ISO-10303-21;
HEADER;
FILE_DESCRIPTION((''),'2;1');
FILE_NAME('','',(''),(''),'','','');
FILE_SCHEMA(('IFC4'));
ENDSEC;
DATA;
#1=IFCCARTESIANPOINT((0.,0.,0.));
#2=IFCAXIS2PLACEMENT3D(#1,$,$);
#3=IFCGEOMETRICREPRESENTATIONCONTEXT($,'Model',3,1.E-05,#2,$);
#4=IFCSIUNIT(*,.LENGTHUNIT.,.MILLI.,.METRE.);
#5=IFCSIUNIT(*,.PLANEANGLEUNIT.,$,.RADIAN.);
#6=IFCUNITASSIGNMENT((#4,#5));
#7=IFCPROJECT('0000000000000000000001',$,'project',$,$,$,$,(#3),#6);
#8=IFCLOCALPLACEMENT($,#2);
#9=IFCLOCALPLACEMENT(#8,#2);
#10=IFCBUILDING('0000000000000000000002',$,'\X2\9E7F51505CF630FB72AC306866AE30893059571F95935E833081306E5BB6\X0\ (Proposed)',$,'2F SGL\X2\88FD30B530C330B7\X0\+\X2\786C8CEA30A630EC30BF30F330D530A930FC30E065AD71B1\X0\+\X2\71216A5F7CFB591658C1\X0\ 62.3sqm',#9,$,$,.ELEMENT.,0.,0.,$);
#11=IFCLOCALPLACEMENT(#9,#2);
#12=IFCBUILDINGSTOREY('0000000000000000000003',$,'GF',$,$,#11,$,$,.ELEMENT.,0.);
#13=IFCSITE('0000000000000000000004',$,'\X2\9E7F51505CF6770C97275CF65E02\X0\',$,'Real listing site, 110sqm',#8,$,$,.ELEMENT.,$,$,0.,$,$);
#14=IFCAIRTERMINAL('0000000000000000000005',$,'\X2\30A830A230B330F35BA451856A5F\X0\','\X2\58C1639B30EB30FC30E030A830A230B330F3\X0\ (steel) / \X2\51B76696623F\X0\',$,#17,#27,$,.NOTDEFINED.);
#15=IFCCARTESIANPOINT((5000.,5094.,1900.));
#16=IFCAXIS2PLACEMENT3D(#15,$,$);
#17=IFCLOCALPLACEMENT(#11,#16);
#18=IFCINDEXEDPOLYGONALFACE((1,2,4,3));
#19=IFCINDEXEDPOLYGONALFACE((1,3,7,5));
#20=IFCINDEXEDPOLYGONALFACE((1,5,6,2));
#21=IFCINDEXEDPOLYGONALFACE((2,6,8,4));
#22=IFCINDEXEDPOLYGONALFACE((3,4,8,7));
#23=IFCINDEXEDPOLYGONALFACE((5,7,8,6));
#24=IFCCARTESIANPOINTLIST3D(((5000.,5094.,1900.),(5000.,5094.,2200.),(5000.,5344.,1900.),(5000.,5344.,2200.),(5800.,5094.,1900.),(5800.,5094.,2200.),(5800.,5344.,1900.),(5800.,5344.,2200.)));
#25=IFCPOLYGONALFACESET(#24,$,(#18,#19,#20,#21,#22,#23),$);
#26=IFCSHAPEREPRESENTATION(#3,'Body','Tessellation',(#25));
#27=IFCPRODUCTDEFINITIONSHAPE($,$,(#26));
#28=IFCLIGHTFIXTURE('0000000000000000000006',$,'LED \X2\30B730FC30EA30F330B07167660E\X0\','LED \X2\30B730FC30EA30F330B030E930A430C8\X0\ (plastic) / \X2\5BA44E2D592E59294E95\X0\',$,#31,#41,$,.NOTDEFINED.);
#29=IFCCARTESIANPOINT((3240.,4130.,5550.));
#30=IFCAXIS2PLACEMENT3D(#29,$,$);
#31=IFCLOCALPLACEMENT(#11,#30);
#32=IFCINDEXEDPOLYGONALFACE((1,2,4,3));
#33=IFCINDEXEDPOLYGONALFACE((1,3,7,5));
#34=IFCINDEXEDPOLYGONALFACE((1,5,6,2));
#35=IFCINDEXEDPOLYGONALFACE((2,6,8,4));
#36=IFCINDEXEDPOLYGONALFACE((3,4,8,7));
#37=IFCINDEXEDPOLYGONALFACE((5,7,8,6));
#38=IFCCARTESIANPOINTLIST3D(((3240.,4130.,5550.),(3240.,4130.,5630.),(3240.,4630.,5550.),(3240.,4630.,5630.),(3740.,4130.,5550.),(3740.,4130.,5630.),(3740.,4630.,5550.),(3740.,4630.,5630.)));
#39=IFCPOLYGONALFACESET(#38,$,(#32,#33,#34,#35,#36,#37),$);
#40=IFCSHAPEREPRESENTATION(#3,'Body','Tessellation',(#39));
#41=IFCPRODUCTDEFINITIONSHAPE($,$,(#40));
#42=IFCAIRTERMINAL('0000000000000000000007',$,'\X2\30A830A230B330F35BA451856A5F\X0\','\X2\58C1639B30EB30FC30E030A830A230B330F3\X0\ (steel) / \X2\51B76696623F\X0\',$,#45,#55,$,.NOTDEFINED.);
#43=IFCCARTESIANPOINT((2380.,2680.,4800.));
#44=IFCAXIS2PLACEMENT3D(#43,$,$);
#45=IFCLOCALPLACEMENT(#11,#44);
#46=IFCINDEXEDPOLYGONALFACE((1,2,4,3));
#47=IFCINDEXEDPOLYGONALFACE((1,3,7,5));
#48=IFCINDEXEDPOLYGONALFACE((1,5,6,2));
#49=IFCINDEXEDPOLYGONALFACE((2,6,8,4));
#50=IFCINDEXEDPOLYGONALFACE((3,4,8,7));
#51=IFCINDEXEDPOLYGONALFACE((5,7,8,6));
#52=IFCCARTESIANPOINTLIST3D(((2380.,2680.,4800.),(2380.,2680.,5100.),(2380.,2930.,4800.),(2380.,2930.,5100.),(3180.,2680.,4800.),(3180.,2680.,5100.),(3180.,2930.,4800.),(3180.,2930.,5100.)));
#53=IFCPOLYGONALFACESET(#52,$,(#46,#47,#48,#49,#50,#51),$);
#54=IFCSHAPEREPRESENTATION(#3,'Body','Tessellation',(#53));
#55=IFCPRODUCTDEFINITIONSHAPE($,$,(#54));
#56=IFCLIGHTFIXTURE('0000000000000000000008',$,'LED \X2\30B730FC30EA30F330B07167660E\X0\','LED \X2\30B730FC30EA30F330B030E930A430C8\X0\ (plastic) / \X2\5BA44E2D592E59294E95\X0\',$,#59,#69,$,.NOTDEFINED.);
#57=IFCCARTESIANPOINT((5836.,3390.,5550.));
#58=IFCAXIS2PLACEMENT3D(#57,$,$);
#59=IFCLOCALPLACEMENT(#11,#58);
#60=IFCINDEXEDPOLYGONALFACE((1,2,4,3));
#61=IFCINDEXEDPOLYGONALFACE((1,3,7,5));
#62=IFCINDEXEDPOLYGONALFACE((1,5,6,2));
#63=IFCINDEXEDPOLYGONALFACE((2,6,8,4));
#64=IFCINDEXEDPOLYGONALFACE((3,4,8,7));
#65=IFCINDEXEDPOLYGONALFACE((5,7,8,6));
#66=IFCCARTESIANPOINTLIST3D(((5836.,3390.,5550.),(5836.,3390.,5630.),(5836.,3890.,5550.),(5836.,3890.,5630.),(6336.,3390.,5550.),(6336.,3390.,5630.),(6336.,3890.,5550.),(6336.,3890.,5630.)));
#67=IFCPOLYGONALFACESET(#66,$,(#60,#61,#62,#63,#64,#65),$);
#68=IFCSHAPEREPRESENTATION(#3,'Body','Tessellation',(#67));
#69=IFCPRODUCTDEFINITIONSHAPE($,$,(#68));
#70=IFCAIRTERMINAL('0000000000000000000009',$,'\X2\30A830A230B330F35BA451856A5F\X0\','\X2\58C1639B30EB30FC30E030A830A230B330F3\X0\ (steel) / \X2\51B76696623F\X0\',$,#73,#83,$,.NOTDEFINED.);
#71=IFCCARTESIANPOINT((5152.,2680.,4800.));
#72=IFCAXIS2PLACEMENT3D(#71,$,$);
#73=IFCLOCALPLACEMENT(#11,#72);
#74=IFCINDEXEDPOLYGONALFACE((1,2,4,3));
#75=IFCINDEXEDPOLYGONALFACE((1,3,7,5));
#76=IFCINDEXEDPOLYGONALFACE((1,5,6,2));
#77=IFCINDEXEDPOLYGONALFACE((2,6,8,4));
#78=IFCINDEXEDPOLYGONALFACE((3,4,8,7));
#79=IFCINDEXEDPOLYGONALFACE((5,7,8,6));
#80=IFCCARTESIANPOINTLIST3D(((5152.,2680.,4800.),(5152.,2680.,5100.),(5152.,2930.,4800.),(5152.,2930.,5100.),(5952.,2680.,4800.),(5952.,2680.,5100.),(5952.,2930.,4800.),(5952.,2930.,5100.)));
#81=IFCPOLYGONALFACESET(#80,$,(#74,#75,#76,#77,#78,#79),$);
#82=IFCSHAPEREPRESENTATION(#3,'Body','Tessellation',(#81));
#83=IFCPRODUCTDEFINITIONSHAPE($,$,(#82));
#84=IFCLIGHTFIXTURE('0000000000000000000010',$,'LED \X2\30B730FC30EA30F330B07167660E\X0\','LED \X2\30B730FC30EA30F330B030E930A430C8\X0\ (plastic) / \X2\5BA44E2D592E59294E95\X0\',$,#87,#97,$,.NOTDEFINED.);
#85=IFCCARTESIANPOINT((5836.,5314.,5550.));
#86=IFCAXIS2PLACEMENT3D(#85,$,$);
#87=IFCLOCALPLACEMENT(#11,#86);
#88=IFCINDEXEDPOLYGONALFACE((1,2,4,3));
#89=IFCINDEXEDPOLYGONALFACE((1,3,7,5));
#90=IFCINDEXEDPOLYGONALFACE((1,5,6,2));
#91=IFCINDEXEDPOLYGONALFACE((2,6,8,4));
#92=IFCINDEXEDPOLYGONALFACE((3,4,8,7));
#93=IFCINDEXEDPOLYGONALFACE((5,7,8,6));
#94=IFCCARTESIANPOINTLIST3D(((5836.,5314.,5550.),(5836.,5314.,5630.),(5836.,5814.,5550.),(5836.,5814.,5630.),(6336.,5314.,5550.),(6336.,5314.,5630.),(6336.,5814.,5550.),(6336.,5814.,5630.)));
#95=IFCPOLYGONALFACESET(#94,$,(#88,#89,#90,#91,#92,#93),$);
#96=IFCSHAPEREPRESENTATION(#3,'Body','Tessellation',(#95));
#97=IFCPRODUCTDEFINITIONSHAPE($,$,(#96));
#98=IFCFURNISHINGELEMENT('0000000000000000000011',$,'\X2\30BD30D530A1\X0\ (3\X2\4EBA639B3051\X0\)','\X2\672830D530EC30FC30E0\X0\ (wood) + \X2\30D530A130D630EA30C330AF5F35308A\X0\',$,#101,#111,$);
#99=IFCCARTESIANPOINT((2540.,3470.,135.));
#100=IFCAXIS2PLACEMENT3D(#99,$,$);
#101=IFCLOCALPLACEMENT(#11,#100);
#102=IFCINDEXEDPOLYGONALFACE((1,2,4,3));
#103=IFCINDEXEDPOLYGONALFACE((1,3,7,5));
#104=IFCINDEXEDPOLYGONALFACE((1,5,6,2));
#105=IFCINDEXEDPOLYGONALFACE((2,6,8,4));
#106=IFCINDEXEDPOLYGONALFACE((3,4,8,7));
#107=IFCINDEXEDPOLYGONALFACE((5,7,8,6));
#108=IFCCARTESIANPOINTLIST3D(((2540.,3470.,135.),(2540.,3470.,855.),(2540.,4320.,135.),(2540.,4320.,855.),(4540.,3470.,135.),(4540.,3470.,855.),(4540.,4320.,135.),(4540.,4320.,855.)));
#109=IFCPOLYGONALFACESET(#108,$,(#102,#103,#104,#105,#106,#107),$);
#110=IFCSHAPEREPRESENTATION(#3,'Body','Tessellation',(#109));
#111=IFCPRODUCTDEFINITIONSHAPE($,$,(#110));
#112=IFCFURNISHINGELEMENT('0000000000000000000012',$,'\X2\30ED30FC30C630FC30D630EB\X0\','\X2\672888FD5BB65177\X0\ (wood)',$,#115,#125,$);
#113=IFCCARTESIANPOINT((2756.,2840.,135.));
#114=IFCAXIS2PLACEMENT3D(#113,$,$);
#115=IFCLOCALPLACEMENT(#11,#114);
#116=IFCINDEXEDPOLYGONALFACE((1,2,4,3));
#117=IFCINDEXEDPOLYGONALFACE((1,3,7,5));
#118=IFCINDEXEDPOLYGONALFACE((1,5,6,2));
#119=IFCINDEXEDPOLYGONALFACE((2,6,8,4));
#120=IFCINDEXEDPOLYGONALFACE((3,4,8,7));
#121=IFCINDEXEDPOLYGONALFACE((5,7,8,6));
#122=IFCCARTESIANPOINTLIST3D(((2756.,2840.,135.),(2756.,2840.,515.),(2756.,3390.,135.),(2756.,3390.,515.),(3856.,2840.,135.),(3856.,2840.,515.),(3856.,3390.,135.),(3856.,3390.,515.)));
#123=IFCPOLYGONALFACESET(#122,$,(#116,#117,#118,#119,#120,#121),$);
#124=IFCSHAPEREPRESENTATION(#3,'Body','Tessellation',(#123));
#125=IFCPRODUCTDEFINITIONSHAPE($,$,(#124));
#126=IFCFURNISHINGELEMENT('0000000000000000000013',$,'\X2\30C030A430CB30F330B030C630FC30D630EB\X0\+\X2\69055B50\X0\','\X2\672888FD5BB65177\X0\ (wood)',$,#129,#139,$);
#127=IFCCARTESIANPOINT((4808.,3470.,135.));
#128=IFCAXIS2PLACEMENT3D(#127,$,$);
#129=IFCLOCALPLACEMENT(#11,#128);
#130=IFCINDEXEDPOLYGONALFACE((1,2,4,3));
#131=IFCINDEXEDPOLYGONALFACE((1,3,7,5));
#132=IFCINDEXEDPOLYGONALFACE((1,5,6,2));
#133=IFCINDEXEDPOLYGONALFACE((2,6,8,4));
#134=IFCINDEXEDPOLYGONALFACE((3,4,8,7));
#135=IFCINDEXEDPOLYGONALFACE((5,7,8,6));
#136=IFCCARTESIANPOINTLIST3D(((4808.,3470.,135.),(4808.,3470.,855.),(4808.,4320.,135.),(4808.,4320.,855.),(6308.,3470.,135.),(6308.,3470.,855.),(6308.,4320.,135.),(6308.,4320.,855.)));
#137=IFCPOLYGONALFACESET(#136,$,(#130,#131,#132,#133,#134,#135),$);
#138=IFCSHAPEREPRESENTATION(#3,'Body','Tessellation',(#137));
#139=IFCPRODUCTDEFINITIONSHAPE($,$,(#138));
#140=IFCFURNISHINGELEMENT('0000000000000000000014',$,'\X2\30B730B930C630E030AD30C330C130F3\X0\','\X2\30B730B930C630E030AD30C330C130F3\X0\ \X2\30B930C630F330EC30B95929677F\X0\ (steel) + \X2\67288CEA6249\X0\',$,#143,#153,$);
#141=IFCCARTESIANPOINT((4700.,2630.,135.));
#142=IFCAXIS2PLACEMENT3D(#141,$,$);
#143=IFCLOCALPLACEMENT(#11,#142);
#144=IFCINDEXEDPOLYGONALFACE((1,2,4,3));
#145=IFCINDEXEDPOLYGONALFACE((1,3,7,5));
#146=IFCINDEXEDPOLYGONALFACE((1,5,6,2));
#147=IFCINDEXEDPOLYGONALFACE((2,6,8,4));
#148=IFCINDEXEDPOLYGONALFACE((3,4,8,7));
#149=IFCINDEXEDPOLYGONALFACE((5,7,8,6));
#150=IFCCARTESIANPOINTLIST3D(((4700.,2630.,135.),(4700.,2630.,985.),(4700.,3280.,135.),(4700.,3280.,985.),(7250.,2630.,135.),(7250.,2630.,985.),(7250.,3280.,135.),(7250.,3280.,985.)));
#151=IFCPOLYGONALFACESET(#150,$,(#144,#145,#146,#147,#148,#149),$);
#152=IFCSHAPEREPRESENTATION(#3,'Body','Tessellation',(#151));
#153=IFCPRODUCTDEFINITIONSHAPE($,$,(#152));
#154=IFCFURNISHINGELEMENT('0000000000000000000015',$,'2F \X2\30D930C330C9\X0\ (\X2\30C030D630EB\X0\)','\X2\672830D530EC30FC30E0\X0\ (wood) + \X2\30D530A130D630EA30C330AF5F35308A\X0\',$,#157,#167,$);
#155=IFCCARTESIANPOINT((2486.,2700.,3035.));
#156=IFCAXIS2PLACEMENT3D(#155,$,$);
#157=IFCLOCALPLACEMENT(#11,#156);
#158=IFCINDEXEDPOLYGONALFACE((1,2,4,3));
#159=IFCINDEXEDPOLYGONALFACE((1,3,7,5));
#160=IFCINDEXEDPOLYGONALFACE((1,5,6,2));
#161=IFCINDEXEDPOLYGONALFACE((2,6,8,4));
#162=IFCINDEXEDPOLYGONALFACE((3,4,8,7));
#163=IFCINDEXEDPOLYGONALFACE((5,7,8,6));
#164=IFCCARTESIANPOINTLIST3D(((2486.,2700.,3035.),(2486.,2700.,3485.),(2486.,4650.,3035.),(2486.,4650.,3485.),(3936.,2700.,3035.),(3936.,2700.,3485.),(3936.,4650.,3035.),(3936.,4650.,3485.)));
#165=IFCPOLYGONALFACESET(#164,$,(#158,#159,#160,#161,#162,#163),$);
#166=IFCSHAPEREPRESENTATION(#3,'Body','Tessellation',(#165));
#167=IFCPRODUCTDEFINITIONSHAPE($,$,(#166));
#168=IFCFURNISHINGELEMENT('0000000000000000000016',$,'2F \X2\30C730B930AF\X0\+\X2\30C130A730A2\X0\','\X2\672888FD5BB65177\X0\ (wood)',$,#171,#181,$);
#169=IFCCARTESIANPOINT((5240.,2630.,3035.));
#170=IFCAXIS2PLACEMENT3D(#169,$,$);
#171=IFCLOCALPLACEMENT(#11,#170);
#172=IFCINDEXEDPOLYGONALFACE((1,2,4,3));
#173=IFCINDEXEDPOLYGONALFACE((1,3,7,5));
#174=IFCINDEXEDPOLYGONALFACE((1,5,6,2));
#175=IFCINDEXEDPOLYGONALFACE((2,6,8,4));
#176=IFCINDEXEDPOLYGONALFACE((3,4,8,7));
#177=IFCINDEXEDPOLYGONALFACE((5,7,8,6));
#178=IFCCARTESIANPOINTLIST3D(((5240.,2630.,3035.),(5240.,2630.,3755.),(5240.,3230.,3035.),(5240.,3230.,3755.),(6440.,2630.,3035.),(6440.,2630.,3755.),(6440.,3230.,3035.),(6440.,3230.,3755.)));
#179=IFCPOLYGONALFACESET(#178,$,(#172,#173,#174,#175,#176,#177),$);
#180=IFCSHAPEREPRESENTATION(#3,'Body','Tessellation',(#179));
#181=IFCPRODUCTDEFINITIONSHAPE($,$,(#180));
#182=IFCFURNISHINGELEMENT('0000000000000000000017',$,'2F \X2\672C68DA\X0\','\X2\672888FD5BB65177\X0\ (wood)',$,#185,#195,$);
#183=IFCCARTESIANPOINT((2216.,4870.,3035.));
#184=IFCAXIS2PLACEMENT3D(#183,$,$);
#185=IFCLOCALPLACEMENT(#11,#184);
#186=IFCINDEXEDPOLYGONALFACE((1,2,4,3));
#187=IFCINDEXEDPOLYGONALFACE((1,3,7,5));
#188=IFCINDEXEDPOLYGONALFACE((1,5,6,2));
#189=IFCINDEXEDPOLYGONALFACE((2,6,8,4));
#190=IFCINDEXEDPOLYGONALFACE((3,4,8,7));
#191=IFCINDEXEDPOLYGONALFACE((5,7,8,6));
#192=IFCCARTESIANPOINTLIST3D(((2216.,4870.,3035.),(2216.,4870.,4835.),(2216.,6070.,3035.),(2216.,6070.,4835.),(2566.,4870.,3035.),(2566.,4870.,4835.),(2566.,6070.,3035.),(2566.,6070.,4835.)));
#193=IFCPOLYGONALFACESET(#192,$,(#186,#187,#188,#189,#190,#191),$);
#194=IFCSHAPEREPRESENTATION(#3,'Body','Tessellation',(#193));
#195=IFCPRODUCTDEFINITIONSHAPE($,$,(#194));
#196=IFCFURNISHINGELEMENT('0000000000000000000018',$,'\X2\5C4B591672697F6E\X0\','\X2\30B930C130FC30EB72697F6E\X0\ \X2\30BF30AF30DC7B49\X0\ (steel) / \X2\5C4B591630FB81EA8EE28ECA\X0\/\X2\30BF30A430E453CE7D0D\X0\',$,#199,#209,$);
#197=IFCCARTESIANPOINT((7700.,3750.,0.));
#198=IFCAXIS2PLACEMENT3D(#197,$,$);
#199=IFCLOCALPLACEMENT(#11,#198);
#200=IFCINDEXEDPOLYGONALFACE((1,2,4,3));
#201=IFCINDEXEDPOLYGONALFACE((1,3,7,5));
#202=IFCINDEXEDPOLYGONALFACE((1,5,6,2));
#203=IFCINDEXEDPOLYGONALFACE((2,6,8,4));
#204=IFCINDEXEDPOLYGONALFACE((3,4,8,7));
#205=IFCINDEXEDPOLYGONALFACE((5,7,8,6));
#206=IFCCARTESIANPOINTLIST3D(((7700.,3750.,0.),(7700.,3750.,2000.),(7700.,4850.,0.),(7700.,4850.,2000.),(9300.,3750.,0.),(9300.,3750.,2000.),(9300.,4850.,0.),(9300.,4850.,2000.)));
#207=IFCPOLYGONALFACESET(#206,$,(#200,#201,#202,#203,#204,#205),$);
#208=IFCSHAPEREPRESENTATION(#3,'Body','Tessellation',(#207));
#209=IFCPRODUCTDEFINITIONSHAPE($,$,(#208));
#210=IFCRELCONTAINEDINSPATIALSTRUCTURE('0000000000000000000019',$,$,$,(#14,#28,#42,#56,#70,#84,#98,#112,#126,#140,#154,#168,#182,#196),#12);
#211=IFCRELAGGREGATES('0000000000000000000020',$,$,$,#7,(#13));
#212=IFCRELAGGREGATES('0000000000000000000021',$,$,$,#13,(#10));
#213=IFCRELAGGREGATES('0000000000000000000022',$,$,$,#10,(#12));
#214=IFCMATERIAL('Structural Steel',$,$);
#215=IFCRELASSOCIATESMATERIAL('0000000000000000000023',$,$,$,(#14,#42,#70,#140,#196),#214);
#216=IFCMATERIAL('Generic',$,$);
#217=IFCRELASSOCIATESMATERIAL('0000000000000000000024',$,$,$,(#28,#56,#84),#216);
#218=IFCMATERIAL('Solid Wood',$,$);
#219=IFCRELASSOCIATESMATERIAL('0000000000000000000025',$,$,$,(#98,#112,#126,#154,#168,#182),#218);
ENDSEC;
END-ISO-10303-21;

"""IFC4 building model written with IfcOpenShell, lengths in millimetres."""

from ifc_helpers import new_model, si_unit, frame, frame_2d, origin, place, context, project, spatial, rectangle, extrude, material, element, save


model = new_model("IFC4")

# Units and contexts
model_context = context("Model", 3, precision=1e-05, world=origin())
ifc_project = project(units=[si_unit("LENGTHUNIT", "METRE", prefix="MILLI"), si_unit("PLANEANGLEUNIT", "RADIAN")], contexts=[model_context])

# Site, building, storey
site_placement = place(None, origin())
site = spatial("IfcSite", under=ifc_project, at=site_placement, Name="鹿児島県霧島市", ObjectType="Real listing site, 110sqm", CompositionType="ELEMENT", RefElevation=0.0)
building_placement = place(site_placement, origin())
building = spatial("IfcBuilding", under=site, at=building_placement, Name="鹿児島・犬と暮らす土間広めの家 (Proposed)", ObjectType="2F SGL製サッシ+硬質ウレタンフォーム断熱+無機系外壁 62.3sqm", CompositionType="ELEMENT", ElevationOfRefHeight=0.0, ElevationOfTerrain=0.0)
storey_placement = place(building_placement, origin())
storey = spatial("IfcBuildingStorey", under=building, at=storey_placement, Name="GF", CompositionType="ELEMENT", Elevation=0.0)

# Shared definitions
ifc_material_1 = material(Name="Solid Wood")

# Shared definitions
ifc_material_2 = material(Name="Structural Steel")

# Shared definitions
ifc_material_3 = material(Name="Generic")

# Air terminal
air_terminal_1_placement = place(storey_placement, frame((5000.0, 5094.0, 1900.0)))
element("IfcAirTerminal", 1, at=air_terminal_1_placement, inside=storey, material=ifc_material_2, Name="エアコン室内機", Description="壁掛ルームエアコン (steel) / 冷暖房", PredefinedType="NOTDEFINED", context=model_context, shape_type="SweptSolid", body=[
    extrude(rectangle(XDim=800.0, YDim=250.0, at=frame_2d((400.0, 125.0))), frame((5000.0, 5094.0, 1900.0)), (0.0, 0.0, 1.0), 300.0),
])

# Light fixture
light_fixture_1_placement = place(storey_placement, frame((3240.0, 4130.0, 5550.0)))
element("IfcLightFixture", 2, at=light_fixture_1_placement, inside=storey, material=ifc_material_3, Name="LED シーリング照明", Description="LED シーリングライト (plastic) / 室中央天井", PredefinedType="NOTDEFINED", context=model_context, shape_type="SweptSolid", body=[
    extrude(rectangle(XDim=500.0, YDim=500.0, at=frame_2d((250.0, 250.0))), frame((3240.0, 4130.0, 5550.0)), (0.0, 0.0, 1.0), 80.0),
])

# Air terminal
air_terminal_2_placement = place(storey_placement, frame((2380.0, 2680.0, 4800.0)))
element("IfcAirTerminal", 3, at=air_terminal_2_placement, inside=storey, material=ifc_material_2, Name="エアコン室内機", Description="壁掛ルームエアコン (steel) / 冷暖房", PredefinedType="NOTDEFINED", context=model_context, shape_type="SweptSolid", body=[
    extrude(rectangle(XDim=800.0, YDim=250.0, at=frame_2d((400.0, 125.0))), frame((2380.0, 2680.0, 4800.0)), (0.0, 0.0, 1.0), 300.0),
])

# Light fixture
light_fixture_2_placement = place(storey_placement, frame((5836.0, 3390.0, 5550.0)))
element("IfcLightFixture", 4, at=light_fixture_2_placement, inside=storey, material=ifc_material_3, Name="LED シーリング照明", Description="LED シーリングライト (plastic) / 室中央天井", PredefinedType="NOTDEFINED", context=model_context, shape_type="SweptSolid", body=[
    extrude(rectangle(XDim=500.0, YDim=500.0, at=frame_2d((250.0, 250.0))), frame((5836.0, 3390.0, 5550.0)), (0.0, 0.0, 1.0), 80.0),
])

# Air terminal
air_terminal_3_placement = place(storey_placement, frame((5152.0, 2680.0, 4800.0)))
element("IfcAirTerminal", 5, at=air_terminal_3_placement, inside=storey, material=ifc_material_2, Name="エアコン室内機", Description="壁掛ルームエアコン (steel) / 冷暖房", PredefinedType="NOTDEFINED", context=model_context, shape_type="SweptSolid", body=[
    extrude(rectangle(XDim=800.0, YDim=250.0, at=frame_2d((400.0, 125.0))), frame((5152.0, 2680.0, 4800.0)), (0.0, 0.0, 1.0), 300.0),
])

# Light fixture
light_fixture_3_placement = place(storey_placement, frame((5836.0, 5314.0, 5550.0)))
element("IfcLightFixture", 6, at=light_fixture_3_placement, inside=storey, material=ifc_material_3, Name="LED シーリング照明", Description="LED シーリングライト (plastic) / 室中央天井", PredefinedType="NOTDEFINED", context=model_context, shape_type="SweptSolid", body=[
    extrude(rectangle(XDim=500.0, YDim=500.0, at=frame_2d((250.0, 250.0))), frame((5836.0, 5314.0, 5550.0)), (0.0, 0.0, 1.0), 80.0),
])

# Furnishing elements
furnishing_1_placement = place(storey_placement, frame((2540.0, 3470.0, 135.0)))
element("IfcFurnishingElement", 7, at=furnishing_1_placement, inside=storey, material=ifc_material_1, Name="ソファ (3人掛け)", Description="木フレーム (wood) + ファブリック張り", context=model_context, shape_type="SweptSolid", body=[
    extrude(rectangle(XDim=2000.0, YDim=850.0, at=frame_2d((1000.0, 425.0))), frame((2540.0, 3470.0, 135.0)), (0.0, 0.0, 1.0), 720.0),
])
furnishing_2_placement = place(storey_placement, frame((2756.0, 2840.0, 135.0)))
element("IfcFurnishingElement", 8, at=furnishing_2_placement, inside=storey, material=ifc_material_1, Name="ローテーブル", Description="木製家具 (wood)", context=model_context, shape_type="SweptSolid", body=[
    extrude(rectangle(XDim=1100.0, YDim=550.0, at=frame_2d((550.0, 275.0))), frame((2756.0, 2840.0, 135.0)), (0.0, 0.0, 1.0), 380.0),
])
furnishing_3_placement = place(storey_placement, frame((4808.0, 3470.0, 135.0)))
element("IfcFurnishingElement", 9, at=furnishing_3_placement, inside=storey, material=ifc_material_1, Name="ダイニングテーブル+椅子", Description="木製家具 (wood)", context=model_context, shape_type="SweptSolid", body=[
    extrude(rectangle(XDim=1500.0, YDim=850.0, at=frame_2d((750.0, 425.0))), frame((4808.0, 3470.0, 135.0)), (0.0, 0.0, 1.0), 720.0),
])
furnishing_4_placement = place(storey_placement, frame((4700.0, 2630.0, 135.0)))
element("IfcFurnishingElement", 10, at=furnishing_4_placement, inside=storey, material=ifc_material_2, Name="システムキッチン", Description="システムキッチン ステンレス天板 (steel) + 木質扉", context=model_context, shape_type="SweptSolid", body=[
    extrude(rectangle(XDim=2550.0, YDim=650.0, at=frame_2d((1275.0, 325.0))), frame((4700.0, 2630.0, 135.0)), (0.0, 0.0, 1.0), 850.0),
])
furnishing_5_placement = place(storey_placement, frame((2486.0, 2700.0, 3035.0)))
element("IfcFurnishingElement", 11, at=furnishing_5_placement, inside=storey, material=ifc_material_1, Name="2F ベッド (ダブル)", Description="木フレーム (wood) + ファブリック張り", context=model_context, shape_type="SweptSolid", body=[
    extrude(rectangle(XDim=1450.0, YDim=1950.0, at=frame_2d((725.0, 975.0))), frame((2486.0, 2700.0, 3035.0)), (0.0, 0.0, 1.0), 450.0),
])
furnishing_6_placement = place(storey_placement, frame((5240.0, 2630.0, 3035.0)))
element("IfcFurnishingElement", 12, at=furnishing_6_placement, inside=storey, material=ifc_material_1, Name="2F デスク+チェア", Description="木製家具 (wood)", context=model_context, shape_type="SweptSolid", body=[
    extrude(rectangle(XDim=1200.0, YDim=600.0, at=frame_2d((600.0, 300.0))), frame((5240.0, 2630.0, 3035.0)), (0.0, 0.0, 1.0), 720.0),
])
furnishing_7_placement = place(storey_placement, frame((2216.0, 4870.0, 3035.0)))
element("IfcFurnishingElement", 13, at=furnishing_7_placement, inside=storey, material=ifc_material_1, Name="2F 本棚", Description="木製家具 (wood)", context=model_context, shape_type="SweptSolid", body=[
    extrude(rectangle(XDim=350.0, YDim=1200.0, at=frame_2d((175.0, 600.0))), frame((2216.0, 4870.0, 3035.0)), (0.0, 0.0, 1.0), 1800.0),
])
furnishing_8_placement = place(storey_placement, frame((7700.0, 3750.0, 0.0)))
element("IfcFurnishingElement", 14, at=furnishing_8_placement, inside=storey, material=ifc_material_2, Name="屋外物置", Description="スチール物置 タクボ等 (steel) / 屋外・自転車/タイヤ収納", context=model_context, shape_type="SweptSolid", body=[
    extrude(rectangle(XDim=1600.0, YDim=1100.0, at=frame_2d((800.0, 550.0))), frame((7700.0, 3750.0, 0.0)), (0.0, 0.0, 1.0), 2000.0),
])

save(model, "model.ifc")
